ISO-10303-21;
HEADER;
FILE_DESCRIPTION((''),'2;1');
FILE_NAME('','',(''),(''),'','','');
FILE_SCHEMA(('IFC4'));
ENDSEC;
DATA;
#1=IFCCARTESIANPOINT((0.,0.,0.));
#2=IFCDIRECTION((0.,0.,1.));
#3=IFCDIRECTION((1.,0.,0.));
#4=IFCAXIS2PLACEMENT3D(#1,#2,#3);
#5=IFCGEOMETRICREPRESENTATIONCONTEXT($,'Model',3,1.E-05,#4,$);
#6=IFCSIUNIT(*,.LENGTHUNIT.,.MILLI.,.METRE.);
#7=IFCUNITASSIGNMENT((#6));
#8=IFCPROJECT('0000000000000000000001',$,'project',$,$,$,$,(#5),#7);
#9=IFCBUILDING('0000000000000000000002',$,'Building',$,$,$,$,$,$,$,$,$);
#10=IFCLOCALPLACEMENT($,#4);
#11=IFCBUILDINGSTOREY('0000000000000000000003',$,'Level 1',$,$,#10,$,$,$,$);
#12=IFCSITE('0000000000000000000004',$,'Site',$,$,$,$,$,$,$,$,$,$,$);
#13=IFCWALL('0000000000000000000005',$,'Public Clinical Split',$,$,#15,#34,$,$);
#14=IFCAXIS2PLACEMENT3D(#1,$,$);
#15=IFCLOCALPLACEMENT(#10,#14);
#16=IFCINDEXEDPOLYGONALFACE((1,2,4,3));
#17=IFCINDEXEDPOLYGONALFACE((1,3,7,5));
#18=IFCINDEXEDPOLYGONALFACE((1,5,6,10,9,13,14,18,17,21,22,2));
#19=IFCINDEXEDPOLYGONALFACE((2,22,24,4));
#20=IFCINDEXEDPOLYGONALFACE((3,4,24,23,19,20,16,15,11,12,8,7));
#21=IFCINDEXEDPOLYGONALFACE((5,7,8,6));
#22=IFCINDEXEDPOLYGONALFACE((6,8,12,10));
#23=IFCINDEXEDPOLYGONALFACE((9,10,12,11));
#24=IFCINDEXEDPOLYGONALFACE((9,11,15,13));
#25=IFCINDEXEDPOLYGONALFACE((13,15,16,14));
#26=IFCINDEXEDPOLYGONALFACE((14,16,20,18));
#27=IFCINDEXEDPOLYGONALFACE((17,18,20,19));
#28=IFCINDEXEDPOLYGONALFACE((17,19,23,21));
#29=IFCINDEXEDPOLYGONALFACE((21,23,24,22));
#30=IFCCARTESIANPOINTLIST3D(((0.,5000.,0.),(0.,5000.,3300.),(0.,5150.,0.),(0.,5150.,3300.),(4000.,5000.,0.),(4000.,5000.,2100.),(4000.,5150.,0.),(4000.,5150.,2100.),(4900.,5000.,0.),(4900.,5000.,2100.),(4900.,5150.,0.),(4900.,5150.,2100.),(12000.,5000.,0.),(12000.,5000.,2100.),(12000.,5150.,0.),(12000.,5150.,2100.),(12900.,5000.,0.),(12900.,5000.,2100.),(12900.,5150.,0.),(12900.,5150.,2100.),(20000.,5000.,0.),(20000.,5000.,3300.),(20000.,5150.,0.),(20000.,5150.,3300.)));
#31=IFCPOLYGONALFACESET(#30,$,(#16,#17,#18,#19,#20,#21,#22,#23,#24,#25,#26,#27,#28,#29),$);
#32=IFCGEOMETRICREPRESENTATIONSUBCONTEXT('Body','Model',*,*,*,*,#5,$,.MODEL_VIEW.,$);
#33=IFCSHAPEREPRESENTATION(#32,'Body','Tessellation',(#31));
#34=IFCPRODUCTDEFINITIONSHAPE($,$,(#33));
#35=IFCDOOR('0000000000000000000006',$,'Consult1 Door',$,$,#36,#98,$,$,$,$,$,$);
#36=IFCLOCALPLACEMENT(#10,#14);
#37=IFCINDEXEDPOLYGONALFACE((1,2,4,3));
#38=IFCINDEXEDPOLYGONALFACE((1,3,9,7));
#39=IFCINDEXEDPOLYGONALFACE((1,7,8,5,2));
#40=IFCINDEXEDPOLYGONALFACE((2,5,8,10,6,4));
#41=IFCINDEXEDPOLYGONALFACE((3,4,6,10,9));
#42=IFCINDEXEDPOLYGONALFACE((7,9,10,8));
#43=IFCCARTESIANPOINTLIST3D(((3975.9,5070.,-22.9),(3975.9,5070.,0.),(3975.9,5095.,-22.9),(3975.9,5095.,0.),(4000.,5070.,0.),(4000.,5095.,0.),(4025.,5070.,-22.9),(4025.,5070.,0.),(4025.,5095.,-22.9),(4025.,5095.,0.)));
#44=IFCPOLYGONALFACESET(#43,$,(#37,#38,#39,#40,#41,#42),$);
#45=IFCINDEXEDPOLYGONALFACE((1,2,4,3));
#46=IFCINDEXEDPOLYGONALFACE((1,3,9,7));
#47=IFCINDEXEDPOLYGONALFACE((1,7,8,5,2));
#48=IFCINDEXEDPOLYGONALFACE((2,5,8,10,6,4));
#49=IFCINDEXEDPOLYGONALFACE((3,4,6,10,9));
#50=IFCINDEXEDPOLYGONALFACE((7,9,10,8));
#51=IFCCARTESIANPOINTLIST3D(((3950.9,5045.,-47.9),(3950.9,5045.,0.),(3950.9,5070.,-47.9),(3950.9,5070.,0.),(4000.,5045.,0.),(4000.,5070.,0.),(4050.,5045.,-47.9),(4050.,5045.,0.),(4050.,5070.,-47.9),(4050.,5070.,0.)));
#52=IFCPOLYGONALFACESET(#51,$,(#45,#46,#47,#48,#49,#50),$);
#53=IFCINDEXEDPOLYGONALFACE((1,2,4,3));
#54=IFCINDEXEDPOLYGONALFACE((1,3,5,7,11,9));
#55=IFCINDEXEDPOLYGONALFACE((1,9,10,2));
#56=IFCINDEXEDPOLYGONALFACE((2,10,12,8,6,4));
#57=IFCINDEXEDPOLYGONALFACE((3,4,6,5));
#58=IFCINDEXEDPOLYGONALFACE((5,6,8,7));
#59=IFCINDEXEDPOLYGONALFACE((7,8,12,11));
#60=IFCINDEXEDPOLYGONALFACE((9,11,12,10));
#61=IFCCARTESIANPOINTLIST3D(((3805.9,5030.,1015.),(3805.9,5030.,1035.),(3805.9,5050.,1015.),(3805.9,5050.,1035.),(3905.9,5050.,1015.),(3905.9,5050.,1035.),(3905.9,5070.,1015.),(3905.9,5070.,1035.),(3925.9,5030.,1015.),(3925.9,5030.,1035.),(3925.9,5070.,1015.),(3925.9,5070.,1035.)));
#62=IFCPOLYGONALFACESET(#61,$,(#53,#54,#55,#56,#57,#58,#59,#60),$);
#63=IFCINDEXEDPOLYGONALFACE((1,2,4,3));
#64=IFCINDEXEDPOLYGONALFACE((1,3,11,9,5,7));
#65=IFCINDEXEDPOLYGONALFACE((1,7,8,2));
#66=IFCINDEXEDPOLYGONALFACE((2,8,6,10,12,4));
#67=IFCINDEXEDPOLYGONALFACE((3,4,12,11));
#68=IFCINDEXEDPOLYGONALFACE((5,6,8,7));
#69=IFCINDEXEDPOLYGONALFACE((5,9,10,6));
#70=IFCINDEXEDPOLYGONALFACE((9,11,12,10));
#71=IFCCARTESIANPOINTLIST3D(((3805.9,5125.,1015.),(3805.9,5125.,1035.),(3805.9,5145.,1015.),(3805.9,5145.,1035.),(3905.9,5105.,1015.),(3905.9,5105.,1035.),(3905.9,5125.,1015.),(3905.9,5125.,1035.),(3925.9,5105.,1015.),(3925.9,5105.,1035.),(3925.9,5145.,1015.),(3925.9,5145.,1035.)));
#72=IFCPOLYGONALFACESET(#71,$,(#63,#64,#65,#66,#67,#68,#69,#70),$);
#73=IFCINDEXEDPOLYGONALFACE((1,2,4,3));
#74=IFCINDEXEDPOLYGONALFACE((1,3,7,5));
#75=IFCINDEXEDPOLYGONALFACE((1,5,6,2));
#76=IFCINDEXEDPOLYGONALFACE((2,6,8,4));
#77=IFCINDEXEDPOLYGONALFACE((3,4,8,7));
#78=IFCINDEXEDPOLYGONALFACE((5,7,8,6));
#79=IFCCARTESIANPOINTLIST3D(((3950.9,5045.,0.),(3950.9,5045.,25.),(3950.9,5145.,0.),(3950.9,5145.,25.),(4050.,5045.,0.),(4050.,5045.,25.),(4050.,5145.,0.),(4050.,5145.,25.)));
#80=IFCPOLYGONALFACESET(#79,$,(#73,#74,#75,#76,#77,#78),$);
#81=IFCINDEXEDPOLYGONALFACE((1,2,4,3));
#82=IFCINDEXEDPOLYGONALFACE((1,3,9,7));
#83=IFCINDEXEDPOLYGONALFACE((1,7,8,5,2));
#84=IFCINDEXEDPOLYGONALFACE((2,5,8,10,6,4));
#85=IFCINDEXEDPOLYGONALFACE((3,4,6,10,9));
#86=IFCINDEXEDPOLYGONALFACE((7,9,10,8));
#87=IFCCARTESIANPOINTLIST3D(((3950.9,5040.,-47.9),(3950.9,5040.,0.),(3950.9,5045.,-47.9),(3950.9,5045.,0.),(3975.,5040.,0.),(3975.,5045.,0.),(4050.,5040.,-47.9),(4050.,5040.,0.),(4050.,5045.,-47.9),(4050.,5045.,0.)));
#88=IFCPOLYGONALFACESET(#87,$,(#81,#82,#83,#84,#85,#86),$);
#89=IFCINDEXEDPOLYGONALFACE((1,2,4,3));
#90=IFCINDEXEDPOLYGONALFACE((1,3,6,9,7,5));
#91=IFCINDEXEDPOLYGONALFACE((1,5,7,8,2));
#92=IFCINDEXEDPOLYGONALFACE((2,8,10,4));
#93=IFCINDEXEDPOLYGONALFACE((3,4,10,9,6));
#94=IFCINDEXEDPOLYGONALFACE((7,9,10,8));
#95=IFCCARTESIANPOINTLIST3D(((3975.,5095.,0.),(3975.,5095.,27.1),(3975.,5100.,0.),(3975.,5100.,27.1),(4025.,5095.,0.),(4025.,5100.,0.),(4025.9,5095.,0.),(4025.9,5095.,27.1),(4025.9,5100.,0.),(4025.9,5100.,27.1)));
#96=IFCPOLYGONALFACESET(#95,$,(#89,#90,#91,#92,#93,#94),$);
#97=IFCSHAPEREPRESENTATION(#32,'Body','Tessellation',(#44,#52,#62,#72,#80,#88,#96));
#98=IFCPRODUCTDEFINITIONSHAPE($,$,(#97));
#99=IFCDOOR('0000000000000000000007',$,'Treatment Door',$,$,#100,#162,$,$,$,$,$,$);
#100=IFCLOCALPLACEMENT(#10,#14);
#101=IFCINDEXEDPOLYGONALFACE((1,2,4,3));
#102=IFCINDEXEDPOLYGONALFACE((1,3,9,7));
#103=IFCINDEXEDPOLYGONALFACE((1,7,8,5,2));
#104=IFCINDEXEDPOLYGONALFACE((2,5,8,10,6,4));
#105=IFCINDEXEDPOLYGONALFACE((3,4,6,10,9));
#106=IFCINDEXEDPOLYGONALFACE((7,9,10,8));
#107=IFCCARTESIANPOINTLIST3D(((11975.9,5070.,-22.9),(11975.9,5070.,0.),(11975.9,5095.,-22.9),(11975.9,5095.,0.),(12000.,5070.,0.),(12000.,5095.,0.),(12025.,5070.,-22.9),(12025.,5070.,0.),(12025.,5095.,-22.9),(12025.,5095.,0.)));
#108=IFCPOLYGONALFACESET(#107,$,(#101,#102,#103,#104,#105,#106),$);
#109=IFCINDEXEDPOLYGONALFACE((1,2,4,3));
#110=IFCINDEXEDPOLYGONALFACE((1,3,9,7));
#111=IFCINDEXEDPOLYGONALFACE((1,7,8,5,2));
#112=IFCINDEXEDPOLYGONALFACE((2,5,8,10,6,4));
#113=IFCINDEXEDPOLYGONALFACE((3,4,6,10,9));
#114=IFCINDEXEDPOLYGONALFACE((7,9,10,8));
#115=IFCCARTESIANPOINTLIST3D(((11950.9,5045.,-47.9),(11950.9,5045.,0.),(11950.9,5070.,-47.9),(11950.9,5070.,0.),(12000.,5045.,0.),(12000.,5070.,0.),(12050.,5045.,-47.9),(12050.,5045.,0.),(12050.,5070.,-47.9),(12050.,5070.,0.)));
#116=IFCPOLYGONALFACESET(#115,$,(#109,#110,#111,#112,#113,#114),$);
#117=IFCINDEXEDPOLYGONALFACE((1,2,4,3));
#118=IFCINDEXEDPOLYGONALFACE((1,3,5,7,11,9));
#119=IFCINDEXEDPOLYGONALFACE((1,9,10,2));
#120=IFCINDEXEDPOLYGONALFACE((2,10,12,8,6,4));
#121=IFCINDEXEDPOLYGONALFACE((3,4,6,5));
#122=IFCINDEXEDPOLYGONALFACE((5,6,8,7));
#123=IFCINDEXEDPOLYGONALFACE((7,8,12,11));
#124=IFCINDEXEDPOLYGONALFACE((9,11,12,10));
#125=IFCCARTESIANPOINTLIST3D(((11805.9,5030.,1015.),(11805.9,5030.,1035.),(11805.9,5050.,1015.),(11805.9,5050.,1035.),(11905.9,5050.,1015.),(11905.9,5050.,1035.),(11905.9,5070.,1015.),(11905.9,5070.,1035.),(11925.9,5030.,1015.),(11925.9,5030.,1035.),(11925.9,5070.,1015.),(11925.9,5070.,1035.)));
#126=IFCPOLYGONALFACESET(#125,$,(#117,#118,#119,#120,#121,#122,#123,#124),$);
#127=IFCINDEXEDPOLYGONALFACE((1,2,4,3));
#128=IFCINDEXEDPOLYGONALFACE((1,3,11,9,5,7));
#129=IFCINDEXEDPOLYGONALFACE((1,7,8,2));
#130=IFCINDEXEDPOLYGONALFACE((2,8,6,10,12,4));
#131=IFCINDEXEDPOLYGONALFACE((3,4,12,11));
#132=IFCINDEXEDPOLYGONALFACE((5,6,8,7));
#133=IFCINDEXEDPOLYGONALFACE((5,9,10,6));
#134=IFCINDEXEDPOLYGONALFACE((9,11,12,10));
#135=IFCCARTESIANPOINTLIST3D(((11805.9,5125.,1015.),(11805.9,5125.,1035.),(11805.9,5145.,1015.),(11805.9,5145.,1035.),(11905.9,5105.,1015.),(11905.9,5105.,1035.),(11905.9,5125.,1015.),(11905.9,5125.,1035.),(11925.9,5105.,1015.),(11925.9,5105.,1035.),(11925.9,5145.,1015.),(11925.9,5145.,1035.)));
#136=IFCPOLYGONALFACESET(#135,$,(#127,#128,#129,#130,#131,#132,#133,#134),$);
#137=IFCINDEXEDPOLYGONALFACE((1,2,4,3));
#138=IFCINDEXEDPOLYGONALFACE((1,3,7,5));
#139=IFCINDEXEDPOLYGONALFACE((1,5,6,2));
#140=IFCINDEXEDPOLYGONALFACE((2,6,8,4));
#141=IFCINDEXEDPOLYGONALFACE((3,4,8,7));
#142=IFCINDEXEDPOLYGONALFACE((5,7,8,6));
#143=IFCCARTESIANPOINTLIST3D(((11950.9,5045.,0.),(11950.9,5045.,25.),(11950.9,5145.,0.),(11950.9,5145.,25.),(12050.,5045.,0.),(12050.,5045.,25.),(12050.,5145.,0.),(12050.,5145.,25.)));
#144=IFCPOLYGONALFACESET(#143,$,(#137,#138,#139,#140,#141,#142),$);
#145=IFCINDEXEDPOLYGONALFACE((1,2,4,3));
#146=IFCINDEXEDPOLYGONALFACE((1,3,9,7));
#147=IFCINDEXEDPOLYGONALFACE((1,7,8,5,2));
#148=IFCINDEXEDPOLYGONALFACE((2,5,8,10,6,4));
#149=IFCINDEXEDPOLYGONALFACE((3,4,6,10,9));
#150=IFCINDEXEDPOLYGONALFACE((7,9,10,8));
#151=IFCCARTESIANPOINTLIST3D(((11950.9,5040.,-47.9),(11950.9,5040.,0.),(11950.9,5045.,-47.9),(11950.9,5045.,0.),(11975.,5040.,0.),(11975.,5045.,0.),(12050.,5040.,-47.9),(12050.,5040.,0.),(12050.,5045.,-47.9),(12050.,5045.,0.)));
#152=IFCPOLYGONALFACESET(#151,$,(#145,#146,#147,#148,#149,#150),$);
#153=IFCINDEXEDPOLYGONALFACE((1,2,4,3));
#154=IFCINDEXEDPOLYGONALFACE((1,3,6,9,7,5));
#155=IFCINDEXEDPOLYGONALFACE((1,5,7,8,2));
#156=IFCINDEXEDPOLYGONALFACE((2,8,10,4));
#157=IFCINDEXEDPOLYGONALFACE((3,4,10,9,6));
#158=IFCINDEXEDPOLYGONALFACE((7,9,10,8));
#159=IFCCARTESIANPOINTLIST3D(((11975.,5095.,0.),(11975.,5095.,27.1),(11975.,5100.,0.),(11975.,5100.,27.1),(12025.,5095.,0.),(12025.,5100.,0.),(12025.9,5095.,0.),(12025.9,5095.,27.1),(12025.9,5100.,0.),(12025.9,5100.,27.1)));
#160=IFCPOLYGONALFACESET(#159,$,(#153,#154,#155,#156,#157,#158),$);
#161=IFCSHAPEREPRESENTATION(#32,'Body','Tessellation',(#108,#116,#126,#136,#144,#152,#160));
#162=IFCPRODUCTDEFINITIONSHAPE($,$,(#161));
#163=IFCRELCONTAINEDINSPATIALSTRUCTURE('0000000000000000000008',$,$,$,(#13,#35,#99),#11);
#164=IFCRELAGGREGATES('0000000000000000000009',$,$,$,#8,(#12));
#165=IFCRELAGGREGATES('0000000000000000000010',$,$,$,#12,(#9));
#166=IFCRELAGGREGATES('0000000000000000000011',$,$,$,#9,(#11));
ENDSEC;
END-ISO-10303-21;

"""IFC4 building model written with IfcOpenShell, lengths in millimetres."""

from ifc_helpers import new_model, si_unit, frame, origin_with_axes, place, context, subcontext, project, spatial, line, indexed_curve, outline, extrude, element, fill, save


model = new_model("IFC4")

# Units and contexts
model_context = context("Model", 3, precision=1e-05, world=origin_with_axes())
body_context = subcontext(model_context, "Body", "Model", "MODEL_VIEW")
ifc_project = project(units=[si_unit("LENGTHUNIT", "METRE", prefix="MILLI")], contexts=[model_context])

# Site, building, storey
site = spatial("IfcSite", under=ifc_project, Name="Site")
building = spatial("IfcBuilding", under=site, Name="Building")
storey_placement = place(None, origin_with_axes())
storey = spatial("IfcBuildingStorey", under=building, at=storey_placement, Name="Level 1")

# Wall, openings, doors
wall_1_placement = place(storey_placement, frame((0.0, 5000.0, 0.0), z_axis=(0.0, 0.0, 1.0), x_axis=(1.0, 0.0, 0.0)))
wall_1 = element("IfcWall", 1, at=wall_1_placement, inside=storey, Name="Public Clinical Split", context=body_context, shape_type="SweptSolid", body=[
    extrude(outline(indexed_curve([(0.0, 0.0), (0.0, 150.0), (20000.0, 150.0), (20000.0, 0.0), (0.0, 0.0)], self_intersect=False)), origin_with_axes(), (0.0, 0.0, 1.0), 3300.0),
])
opening_1_placement = place(wall_1_placement, frame((4000.0, -100.0, 0.0), z_axis=(0.0, 0.0, 1.0), x_axis=(1.0, 0.0, 0.0)))
opening_1 = element("IfcOpeningElement", 2, at=opening_1_placement, cuts=wall_1, context=body_context, shape_type="SweptSolid", body=[
    extrude(outline(indexed_curve([(0.0, 0.0), (0.0, 350.0), (900.0, 350.0), (900.0, 0.0), (0.0, 0.0)], self_intersect=False)), origin_with_axes(), (0.0, 0.0, 1.0), 2100.0),
])
opening_2_placement = place(wall_1_placement, frame((12000.0, -100.0, 0.0), z_axis=(0.0, 0.0, 1.0), x_axis=(1.0, 0.0, 0.0)))
opening_2 = element("IfcOpeningElement", 3, at=opening_2_placement, cuts=wall_1, context=body_context, shape_type="SweptSolid", body=[
    extrude(outline(indexed_curve([(0.0, 0.0), (0.0, 350.0), (900.0, 350.0), (900.0, 0.0), (0.0, 0.0)], self_intersect=False)), origin_with_axes(), (0.0, 0.0, 1.0), 2100.0),
])
door_1_placement = place(opening_1_placement, frame((0.0, 145.0, 0.0), z_axis=(0.0, 0.0, 1.0), x_axis=(1.0, 0.0, 0.0)))
door_1 = element("IfcDoor", 4, at=door_1_placement, inside=storey, Name="Consult1 Door", context=body_context, shape_type="SweptSolid", body=[
    extrude(outline(indexed_curve([(0.0, 0.0), (0.0, 2.1), (0.9, 2.1), (0.9, 0.0), (-24.1, 0.0), (-24.1, -22.9), (25.0, -22.9), (25.0, 0.0)], segments=[line(1, 2, 3, 4, 5, 6, 7, 8, 1)])), frame((0.0, 25.0, 0.0), z_axis=(0.0, -1.0, 0.0), x_axis=(1.0, 0.0, 0.0)), (0.0, 0.0, -1.0), 25.0),
    extrude(outline(indexed_curve([(0.0, 0.0), (0.0, 2.1), (0.9, 2.1), (0.9, 0.0), (-49.1, 0.0), (-49.1, -47.9), (50.0, -47.9), (50.0, 0.0)], segments=[line(1, 2, 3, 4, 5, 6, 7, 8, 1)])), frame((0.0, 0.0, 0.0), z_axis=(0.0, -1.0, 0.0), x_axis=(1.0, 0.0, 0.0)), (0.0, 0.0, -1.0), 25.0),
    extrude(outline(indexed_curve([(0.0, 0.0), (-49.1, 0.0), (-49.1, 35.0), (0.0, 35.0)], segments=[line(1, 2, 3, 4, 1)])), frame((25.0, 25.0, 25.0), z_axis=(0.0, 0.0, 1.0), x_axis=(1.0, 0.0, 0.0)), (0.0, 0.0, 1.0), -47.9),
    extrude(outline(indexed_curve([(0.0, 0.0), (0.0, -40.0), (-120.0, -40.0), (-120.0, -20.0), (-20.0, -20.0), (-20.0, 0.0)], segments=[line(1, 2, 3, 4, 5, 6, 1)])), frame((-74.1, 25.0, 1015.0), z_axis=(0.0, 0.0, 1.0), x_axis=(1.0, 0.0, 0.0)), (0.0, 0.0, 1.0), 20.0),
    extrude(outline(indexed_curve([(0.0, 0.0), (0.0, 40.0), (-120.0, 40.0), (-120.0, 20.0), (-20.0, 20.0), (-20.0, 0.0)], segments=[line(1, 2, 3, 4, 5, 6, 1)])), frame((-74.1, 60.0, 1015.0), z_axis=(0.0, 0.0, 1.0), x_axis=(1.0, 0.0, 0.0)), (0.0, 0.0, 1.0), 20.0),
    extrude(outline(indexed_curve([(0.0, 0.0), (-99.1, 0.0), (-99.1, 100.0), (0.0, 100.0)], segments=[line(1, 2, 3, 4, 1)])), frame((50.0, 0.0, 0.0), z_axis=(0.0, 0.0, 1.0), x_axis=(1.0, 0.0, 0.0)), (0.0, 0.0, 1.0), 25.0),
    extrude(outline(indexed_curve([(0.0, 0.0), (0.0, 27.1), (50.9, 27.1), (50.9, 0.0), (-24.1, 0.0), (-24.1, -47.9), (75.0, -47.9), (75.0, 0.0)], segments=[line(1, 2, 3, 4, 5, 6, 7, 8, 1)])), frame((-25.0, -5.0, 0.0), z_axis=(0.0, -1.0, 0.0), x_axis=(1.0, 0.0, 0.0)), (0.0, 0.0, -1.0), 5.0),
    extrude(outline(indexed_curve([(0.0, 0.0), (0.0, 27.1), (50.9, 27.1), (50.9, 0.0), (0.9, 0.0), (0.9, -22.9), (50.0, -22.9), (50.0, 0.0)], segments=[line(1, 2, 3, 4, 5, 6, 7, 8, 1)])), frame((-25.0, 50.0, 0.0), z_axis=(0.0, -1.0, 0.0), x_axis=(1.0, 0.0, 0.0)), (0.0, 0.0, -1.0), 5.0),
])
fill(opening_1, door_1)
door_2_placement = place(opening_2_placement, frame((0.0, 145.0, 0.0), z_axis=(0.0, 0.0, 1.0), x_axis=(1.0, 0.0, 0.0)))
door_2 = element("IfcDoor", 5, at=door_2_placement, inside=storey, Name="Treatment Door", context=body_context, shape_type="SweptSolid", body=[
    extrude(outline(indexed_curve([(0.0, 0.0), (0.0, 2.1), (0.9, 2.1), (0.9, 0.0), (-24.1, 0.0), (-24.1, -22.9), (25.0, -22.9), (25.0, 0.0)], segments=[line(1, 2, 3, 4, 5, 6, 7, 8, 1)])), frame((0.0, 25.0, 0.0), z_axis=(0.0, -1.0, 0.0), x_axis=(1.0, 0.0, 0.0)), (0.0, 0.0, -1.0), 25.0),
    extrude(outline(indexed_curve([(0.0, 0.0), (0.0, 2.1), (0.9, 2.1), (0.9, 0.0), (-49.1, 0.0), (-49.1, -47.9), (50.0, -47.9), (50.0, 0.0)], segments=[line(1, 2, 3, 4, 5, 6, 7, 8, 1)])), frame((0.0, 0.0, 0.0), z_axis=(0.0, -1.0, 0.0), x_axis=(1.0, 0.0, 0.0)), (0.0, 0.0, -1.0), 25.0),
    extrude(outline(indexed_curve([(0.0, 0.0), (-49.1, 0.0), (-49.1, 35.0), (0.0, 35.0)], segments=[line(1, 2, 3, 4, 1)])), frame((25.0, 25.0, 25.0), z_axis=(0.0, 0.0, 1.0), x_axis=(1.0, 0.0, 0.0)), (0.0, 0.0, 1.0), -47.9),
    extrude(outline(indexed_curve([(0.0, 0.0), (0.0, -40.0), (-120.0, -40.0), (-120.0, -20.0), (-20.0, -20.0), (-20.0, 0.0)], segments=[line(1, 2, 3, 4, 5, 6, 1)])), frame((-74.1, 25.0, 1015.0), z_axis=(0.0, 0.0, 1.0), x_axis=(1.0, 0.0, 0.0)), (0.0, 0.0, 1.0), 20.0),
    extrude(outline(indexed_curve([(0.0, 0.0), (0.0, 40.0), (-120.0, 40.0), (-120.0, 20.0), (-20.0, 20.0), (-20.0, 0.0)], segments=[line(1, 2, 3, 4, 5, 6, 1)])), frame((-74.1, 60.0, 1015.0), z_axis=(0.0, 0.0, 1.0), x_axis=(1.0, 0.0, 0.0)), (0.0, 0.0, 1.0), 20.0),
    extrude(outline(indexed_curve([(0.0, 0.0), (-99.1, 0.0), (-99.1, 100.0), (0.0, 100.0)], segments=[line(1, 2, 3, 4, 1)])), frame((50.0, 0.0, 0.0), z_axis=(0.0, 0.0, 1.0), x_axis=(1.0, 0.0, 0.0)), (0.0, 0.0, 1.0), 25.0),
    extrude(outline(indexed_curve([(0.0, 0.0), (0.0, 27.1), (50.9, 27.1), (50.9, 0.0), (-24.1, 0.0), (-24.1, -47.9), (75.0, -47.9), (75.0, 0.0)], segments=[line(1, 2, 3, 4, 5, 6, 7, 8, 1)])), frame((-25.0, -5.0, 0.0), z_axis=(0.0, -1.0, 0.0), x_axis=(1.0, 0.0, 0.0)), (0.0, 0.0, -1.0), 5.0),
    extrude(outline(indexed_curve([(0.0, 0.0), (0.0, 27.1), (50.9, 27.1), (50.9, 0.0), (0.9, 0.0), (0.9, -22.9), (50.0, -22.9), (50.0, 0.0)], segments=[line(1, 2, 3, 4, 5, 6, 7, 8, 1)])), frame((-25.0, 50.0, 0.0), z_axis=(0.0, -1.0, 0.0), x_axis=(1.0, 0.0, 0.0)), (0.0, 0.0, -1.0), 5.0),
])
fill(opening_2, door_2)

save(model, "model.ifc")
